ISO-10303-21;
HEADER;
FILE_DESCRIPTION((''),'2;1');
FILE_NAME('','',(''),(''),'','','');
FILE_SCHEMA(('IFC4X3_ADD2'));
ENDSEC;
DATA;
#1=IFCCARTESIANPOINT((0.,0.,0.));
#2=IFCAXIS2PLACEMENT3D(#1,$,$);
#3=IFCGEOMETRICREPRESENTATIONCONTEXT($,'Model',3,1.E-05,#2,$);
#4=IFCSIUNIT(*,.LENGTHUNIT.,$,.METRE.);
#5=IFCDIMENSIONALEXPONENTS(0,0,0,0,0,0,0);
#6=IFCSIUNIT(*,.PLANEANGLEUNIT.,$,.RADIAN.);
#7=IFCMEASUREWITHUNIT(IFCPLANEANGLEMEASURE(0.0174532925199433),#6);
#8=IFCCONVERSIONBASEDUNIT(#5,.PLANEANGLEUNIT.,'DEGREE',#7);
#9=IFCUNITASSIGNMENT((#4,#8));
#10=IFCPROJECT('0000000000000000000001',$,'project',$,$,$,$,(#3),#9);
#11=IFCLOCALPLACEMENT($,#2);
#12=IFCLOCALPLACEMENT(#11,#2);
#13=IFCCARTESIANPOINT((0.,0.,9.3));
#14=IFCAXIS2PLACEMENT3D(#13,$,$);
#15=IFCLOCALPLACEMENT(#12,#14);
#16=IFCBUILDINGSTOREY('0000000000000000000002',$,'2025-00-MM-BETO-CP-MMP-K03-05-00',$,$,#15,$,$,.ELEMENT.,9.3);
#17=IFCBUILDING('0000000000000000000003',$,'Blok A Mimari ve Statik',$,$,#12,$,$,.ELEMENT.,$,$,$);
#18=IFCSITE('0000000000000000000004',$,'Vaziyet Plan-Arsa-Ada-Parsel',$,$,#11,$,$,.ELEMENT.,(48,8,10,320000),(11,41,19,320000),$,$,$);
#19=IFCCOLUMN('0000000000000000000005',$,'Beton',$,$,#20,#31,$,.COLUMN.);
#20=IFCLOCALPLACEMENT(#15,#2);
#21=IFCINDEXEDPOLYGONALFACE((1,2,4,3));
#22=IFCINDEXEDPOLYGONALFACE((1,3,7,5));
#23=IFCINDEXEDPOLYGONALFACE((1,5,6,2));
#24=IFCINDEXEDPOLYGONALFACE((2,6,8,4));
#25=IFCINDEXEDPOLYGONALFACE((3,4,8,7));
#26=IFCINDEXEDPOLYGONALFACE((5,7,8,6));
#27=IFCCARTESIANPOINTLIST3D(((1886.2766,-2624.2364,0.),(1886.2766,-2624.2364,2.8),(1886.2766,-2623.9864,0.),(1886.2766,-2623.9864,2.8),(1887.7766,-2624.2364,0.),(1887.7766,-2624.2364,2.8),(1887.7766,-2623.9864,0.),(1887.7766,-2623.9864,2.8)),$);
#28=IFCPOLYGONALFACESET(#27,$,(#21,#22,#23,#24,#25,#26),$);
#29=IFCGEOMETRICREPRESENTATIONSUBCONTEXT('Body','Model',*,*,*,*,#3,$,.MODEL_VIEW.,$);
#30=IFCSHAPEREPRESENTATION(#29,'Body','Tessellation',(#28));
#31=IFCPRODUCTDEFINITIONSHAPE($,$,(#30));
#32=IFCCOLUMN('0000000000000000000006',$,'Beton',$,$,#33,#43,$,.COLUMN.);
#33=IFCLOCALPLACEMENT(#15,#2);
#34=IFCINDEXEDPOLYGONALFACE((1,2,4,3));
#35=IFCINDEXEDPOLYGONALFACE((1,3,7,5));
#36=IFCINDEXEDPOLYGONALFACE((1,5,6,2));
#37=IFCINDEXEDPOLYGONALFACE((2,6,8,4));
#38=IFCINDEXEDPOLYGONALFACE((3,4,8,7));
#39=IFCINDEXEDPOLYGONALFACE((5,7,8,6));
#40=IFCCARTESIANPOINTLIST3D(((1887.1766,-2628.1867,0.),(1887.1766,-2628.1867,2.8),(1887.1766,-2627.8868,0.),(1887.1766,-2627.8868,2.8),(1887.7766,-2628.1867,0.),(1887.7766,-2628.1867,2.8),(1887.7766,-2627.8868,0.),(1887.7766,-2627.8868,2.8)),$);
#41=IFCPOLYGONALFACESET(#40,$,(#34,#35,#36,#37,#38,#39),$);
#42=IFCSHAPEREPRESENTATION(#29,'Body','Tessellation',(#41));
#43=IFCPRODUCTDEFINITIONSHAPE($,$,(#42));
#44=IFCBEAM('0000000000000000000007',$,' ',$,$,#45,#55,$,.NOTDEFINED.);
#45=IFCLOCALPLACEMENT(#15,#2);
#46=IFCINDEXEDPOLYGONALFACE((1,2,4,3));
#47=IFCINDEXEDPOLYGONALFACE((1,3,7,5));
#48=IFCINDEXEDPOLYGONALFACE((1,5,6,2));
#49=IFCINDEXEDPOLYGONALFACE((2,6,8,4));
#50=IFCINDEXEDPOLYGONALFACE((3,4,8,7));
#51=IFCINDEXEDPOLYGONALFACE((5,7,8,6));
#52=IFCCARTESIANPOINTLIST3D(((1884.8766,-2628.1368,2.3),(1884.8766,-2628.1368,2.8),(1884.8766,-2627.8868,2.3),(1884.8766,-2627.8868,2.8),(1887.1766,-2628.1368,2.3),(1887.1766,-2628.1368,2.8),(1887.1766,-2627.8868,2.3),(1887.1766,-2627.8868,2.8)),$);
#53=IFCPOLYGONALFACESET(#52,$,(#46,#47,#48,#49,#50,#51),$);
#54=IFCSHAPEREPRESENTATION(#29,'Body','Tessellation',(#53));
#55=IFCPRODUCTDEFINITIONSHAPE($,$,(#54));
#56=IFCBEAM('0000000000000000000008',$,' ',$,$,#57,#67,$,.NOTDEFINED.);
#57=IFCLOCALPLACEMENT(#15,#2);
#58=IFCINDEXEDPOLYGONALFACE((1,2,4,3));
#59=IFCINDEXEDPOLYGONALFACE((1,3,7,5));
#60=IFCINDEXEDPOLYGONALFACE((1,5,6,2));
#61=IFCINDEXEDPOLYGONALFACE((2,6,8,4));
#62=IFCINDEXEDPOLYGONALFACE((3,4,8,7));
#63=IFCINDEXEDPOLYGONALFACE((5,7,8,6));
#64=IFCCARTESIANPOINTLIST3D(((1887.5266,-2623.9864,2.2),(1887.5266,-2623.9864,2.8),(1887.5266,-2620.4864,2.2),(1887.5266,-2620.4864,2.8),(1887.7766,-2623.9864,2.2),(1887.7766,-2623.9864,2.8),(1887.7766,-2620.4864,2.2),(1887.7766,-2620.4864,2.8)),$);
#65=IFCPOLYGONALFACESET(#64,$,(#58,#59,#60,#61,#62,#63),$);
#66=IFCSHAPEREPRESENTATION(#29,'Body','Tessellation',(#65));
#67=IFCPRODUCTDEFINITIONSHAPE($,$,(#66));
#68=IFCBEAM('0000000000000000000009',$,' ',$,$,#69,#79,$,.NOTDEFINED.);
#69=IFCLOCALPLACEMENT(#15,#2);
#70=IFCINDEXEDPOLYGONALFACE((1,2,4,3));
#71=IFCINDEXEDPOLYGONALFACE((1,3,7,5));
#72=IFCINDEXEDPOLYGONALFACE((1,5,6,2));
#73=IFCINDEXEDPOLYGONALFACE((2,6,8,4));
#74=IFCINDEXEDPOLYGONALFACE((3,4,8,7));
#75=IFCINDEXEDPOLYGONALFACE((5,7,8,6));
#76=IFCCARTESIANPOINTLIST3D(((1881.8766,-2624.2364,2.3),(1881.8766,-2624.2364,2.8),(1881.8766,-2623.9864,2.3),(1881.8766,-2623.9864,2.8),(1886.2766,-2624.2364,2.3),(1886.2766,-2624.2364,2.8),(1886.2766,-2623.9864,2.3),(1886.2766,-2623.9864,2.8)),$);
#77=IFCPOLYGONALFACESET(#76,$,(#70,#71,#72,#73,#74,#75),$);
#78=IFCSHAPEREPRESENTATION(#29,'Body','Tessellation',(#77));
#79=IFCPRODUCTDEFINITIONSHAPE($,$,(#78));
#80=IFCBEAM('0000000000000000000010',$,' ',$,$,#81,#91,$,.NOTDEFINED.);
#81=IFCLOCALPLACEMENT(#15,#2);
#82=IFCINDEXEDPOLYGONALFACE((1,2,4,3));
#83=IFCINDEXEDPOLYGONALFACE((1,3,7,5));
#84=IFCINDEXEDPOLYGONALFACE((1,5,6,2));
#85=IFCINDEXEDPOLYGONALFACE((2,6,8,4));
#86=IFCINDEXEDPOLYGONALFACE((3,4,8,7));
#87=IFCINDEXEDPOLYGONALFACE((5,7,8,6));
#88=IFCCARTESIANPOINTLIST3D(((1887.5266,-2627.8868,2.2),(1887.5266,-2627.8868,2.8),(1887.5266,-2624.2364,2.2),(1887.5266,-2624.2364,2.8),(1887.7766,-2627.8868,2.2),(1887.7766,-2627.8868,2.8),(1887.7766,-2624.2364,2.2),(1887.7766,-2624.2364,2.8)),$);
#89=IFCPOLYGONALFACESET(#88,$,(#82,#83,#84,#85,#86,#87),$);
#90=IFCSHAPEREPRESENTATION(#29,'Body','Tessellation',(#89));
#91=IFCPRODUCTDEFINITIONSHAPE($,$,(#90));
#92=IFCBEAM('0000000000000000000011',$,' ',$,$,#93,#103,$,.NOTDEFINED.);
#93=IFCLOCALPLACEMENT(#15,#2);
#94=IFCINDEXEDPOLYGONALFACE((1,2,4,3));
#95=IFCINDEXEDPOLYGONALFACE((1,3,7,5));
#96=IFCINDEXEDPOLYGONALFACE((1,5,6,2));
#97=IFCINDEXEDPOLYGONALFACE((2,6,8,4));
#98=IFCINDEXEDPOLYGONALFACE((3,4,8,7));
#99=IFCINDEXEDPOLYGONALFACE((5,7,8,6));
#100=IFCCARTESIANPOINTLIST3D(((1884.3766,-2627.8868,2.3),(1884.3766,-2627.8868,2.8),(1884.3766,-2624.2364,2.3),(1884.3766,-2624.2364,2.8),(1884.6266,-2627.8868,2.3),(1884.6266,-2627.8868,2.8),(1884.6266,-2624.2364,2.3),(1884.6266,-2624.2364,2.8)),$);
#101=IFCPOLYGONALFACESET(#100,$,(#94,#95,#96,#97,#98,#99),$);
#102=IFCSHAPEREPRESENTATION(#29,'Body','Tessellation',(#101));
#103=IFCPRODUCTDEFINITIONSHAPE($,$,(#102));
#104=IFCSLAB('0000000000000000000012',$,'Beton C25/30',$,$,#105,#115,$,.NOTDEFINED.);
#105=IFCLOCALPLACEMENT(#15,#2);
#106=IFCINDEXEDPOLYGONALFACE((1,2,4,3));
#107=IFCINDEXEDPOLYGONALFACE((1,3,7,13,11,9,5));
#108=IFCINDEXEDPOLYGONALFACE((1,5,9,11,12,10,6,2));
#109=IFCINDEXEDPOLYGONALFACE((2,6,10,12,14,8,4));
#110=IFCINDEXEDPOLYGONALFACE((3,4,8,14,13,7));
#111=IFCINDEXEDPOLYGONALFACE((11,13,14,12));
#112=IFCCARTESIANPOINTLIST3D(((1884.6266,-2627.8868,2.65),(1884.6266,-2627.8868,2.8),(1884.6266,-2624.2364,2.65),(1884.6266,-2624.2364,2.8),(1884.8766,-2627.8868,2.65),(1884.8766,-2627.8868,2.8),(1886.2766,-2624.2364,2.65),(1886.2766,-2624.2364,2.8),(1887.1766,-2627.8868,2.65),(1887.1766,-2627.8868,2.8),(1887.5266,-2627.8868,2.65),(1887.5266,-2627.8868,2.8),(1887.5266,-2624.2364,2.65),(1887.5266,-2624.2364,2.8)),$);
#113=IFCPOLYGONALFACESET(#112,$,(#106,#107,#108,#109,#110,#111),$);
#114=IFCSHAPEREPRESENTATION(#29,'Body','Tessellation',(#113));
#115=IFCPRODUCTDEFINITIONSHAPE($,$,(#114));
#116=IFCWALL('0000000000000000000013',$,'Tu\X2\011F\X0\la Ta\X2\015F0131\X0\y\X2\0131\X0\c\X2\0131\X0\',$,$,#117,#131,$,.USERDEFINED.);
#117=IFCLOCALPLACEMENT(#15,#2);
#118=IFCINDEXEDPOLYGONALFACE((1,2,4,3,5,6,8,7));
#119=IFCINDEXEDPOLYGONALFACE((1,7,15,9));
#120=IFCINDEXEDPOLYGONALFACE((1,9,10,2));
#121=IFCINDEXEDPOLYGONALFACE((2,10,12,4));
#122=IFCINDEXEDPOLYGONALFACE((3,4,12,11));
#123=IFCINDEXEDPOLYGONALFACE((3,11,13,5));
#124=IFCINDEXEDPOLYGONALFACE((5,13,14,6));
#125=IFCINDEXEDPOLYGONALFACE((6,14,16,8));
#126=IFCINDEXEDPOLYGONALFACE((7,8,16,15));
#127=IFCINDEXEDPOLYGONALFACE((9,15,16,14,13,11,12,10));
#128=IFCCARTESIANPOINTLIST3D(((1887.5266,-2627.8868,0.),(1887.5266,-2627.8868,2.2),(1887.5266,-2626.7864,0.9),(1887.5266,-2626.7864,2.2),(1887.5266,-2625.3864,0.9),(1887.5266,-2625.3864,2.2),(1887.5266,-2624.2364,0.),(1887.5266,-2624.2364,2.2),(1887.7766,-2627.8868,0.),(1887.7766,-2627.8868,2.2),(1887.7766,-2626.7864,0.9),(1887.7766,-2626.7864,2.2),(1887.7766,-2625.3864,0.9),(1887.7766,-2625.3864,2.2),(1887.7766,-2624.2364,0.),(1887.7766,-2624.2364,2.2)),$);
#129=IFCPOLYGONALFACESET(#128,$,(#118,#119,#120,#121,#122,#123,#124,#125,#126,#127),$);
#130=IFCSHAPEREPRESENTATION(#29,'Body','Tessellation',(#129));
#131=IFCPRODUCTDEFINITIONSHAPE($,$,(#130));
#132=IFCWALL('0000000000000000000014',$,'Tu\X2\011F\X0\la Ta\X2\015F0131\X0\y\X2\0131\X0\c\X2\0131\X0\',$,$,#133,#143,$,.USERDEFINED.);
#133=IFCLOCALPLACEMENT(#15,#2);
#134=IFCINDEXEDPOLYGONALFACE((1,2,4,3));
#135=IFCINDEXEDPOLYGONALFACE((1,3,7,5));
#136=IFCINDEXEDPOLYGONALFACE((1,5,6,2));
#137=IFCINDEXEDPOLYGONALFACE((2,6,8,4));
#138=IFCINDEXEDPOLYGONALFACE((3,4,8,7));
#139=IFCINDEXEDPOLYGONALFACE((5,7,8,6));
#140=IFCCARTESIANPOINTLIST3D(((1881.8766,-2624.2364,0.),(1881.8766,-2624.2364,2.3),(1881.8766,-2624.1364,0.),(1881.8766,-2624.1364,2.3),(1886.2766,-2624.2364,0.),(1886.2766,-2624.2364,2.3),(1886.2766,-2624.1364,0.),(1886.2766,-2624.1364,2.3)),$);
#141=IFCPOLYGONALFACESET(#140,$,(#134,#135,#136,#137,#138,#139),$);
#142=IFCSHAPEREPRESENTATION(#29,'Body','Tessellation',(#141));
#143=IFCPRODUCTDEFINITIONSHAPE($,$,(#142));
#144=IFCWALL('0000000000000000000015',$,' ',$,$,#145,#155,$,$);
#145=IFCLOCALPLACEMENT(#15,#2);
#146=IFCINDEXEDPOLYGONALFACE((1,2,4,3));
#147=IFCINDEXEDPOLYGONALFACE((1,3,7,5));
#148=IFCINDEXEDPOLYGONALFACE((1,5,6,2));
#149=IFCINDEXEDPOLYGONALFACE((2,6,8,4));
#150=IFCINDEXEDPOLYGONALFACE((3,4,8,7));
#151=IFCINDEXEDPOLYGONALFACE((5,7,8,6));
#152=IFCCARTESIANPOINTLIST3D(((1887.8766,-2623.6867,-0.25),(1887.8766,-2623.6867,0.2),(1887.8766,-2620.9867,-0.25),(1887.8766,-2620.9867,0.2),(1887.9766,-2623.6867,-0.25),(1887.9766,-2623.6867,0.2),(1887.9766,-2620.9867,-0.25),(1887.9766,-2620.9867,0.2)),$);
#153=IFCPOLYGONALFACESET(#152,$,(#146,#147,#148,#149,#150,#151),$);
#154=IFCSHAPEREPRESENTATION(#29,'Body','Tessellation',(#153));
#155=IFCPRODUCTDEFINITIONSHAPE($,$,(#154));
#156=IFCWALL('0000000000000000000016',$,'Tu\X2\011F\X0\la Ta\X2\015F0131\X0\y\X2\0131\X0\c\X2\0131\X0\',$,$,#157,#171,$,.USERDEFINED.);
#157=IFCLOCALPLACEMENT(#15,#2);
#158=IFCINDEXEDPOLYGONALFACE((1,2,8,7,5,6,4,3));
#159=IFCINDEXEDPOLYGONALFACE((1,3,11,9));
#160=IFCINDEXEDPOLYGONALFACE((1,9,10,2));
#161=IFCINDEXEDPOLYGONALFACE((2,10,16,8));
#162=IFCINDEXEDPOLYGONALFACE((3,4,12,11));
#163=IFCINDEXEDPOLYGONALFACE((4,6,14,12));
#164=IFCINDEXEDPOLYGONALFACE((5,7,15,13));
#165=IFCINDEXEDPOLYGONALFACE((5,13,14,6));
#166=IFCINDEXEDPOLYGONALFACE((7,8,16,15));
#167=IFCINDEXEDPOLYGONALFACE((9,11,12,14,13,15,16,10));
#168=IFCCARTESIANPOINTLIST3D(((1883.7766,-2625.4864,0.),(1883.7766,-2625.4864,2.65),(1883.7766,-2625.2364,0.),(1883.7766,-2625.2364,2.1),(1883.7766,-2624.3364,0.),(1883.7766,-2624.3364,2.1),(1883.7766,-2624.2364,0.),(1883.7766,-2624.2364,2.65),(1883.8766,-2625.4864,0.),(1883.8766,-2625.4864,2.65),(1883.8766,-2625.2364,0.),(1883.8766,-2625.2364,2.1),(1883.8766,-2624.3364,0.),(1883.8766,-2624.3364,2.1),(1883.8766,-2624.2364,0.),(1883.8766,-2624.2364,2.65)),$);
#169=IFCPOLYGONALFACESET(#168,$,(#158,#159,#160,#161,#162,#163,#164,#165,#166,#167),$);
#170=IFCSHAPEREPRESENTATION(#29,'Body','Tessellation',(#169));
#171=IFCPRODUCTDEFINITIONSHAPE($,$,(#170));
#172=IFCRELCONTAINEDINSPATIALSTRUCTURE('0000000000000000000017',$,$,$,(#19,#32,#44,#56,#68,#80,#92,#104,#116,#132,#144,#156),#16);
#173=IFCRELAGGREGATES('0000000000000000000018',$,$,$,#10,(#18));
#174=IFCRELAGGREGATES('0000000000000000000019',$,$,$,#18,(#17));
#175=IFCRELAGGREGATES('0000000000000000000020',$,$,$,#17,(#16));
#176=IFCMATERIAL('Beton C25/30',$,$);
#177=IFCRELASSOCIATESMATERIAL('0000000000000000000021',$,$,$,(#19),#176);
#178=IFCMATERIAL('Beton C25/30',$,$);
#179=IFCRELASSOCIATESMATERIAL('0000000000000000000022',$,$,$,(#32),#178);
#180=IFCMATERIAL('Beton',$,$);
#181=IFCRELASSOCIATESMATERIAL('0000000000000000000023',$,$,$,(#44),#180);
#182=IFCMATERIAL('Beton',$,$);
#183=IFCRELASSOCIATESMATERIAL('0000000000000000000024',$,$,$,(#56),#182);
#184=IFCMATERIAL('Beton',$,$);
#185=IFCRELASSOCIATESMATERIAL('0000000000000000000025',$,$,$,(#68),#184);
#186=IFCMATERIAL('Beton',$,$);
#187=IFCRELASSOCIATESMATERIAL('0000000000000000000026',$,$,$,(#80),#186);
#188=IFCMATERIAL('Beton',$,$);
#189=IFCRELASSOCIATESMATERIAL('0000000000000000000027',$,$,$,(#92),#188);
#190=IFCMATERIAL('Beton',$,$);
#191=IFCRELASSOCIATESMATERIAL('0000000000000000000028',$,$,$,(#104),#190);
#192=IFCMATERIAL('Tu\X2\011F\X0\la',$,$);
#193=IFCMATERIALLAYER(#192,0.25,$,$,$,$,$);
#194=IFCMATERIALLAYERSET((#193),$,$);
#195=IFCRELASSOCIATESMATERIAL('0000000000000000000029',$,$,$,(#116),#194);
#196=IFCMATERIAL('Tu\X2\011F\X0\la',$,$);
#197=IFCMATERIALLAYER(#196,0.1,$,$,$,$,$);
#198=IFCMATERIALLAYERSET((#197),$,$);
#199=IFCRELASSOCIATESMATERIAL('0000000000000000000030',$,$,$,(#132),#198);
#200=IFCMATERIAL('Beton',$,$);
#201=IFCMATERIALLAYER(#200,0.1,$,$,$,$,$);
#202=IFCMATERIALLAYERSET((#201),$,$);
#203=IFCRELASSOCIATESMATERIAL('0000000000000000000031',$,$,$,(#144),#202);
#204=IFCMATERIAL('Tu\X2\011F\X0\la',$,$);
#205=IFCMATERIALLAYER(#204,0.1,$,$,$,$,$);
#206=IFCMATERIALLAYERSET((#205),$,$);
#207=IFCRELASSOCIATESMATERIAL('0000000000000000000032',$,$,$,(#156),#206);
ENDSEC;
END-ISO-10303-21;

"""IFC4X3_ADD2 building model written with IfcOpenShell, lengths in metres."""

from ifc_helpers import new_model, entity, si_unit, converted_unit, frame, frame_2d, origin, origin_with_axes, place, context, subcontext, project, spatial, polyline, rectangle, outline, extrude, material, layer, layer_set, layer_usage, element, save


model = new_model("IFC4X3_ADD2")

# Units and contexts
model_context = context("Model", 3, precision=1e-05, world=origin())
body_context = subcontext(model_context, "Body", "Model", "MODEL_VIEW")
ifc_project = project(units=[si_unit("LENGTHUNIT", "METRE"), converted_unit("PLANEANGLEUNIT", "DEGREE", entity("IfcPlaneAngleMeasure", 0.0174532925199433), si_unit("PLANEANGLEUNIT", "RADIAN"), dimensions=[0, 0, 0, 0, 0, 0, 0])], contexts=[model_context])

# Site, building, storey
site_placement = place(None, origin())
site = spatial("IfcSite", under=ifc_project, at=site_placement, Name="Vaziyet Plan-Arsa-Ada-Parsel", CompositionType="ELEMENT", RefLatitude=(48, 8, 10, 320000), RefLongitude=(11, 41, 19, 320000))
building_placement = place(site_placement, origin())
building = spatial("IfcBuilding", under=site, at=building_placement, Name="Blok A Mimari ve Statik", CompositionType="ELEMENT")
storey_placement = place(building_placement, frame((0.0, 0.0, 9.3)))
storey = spatial("IfcBuildingStorey", under=building, at=storey_placement, Name="2025-00-MM-BETO-CP-MMP-K03-05-00", CompositionType="ELEMENT", Elevation=9.3)

# Columns
ifc_material_1 = material(Name="Beton C25/30")
column_1_placement = place(storey_placement, frame((1886.2766, -2624.2364, 0.0)))
element("IfcColumn", 1, at=column_1_placement, inside=storey, material=ifc_material_1, Name="Beton", PredefinedType="COLUMN", context=body_context, shape_type="SweptSolid", body=[
    extrude(outline(polyline([(1.5, 0.0), (1.5, 0.25), (0.0, 0.25), (0.0, 0.0), (1.5, 0.0)])), origin_with_axes(), (0.0, 0.0, 1.0), 2.8),
])
ifc_material_2 = material(Name="Beton C25/30")
column_2_placement = place(storey_placement, frame((1887.1766, -2628.1867, 0.0)))
element("IfcColumn", 2, at=column_2_placement, inside=storey, material=ifc_material_2, Name="Beton", PredefinedType="COLUMN", context=body_context, shape_type="SweptSolid", body=[
    extrude(outline(polyline([(0.0, 0.3), (0.0, 0.0), (0.6, 0.0), (0.6, 0.3), (0.0, 0.3)])), origin_with_axes(), (0.0, 0.0, 1.0), 2.8),
])

# Beams
ifc_material_3 = material(Name="Beton")
beam_1_placement = place(storey_placement, frame((1887.1766, -2627.8868, 2.3), z_axis=(0.0, 0.0, 1.0), x_axis=(-1.0, 0.0, 0.0)))
element("IfcBeam", 3, at=beam_1_placement, inside=storey, material=ifc_material_3, Name=" ", PredefinedType="NOTDEFINED", context=body_context, shape_type="SweptSolid", body=[
    extrude(rectangle(XDim=0.25, YDim=0.5, at=frame_2d((0.125, 0.25), x_axis=(1.0, 0.0))), frame((0.0, 0.0, 0.0), z_axis=(1.0, 0.0, 0.0), x_axis=(0.0, 1.0, 0.0)), (0.0, 0.0, 1.0), 2.3),
])
ifc_material_4 = material(Name="Beton")
beam_2_placement = place(storey_placement, frame((1887.7766, -2623.9864, 2.2), z_axis=(0.0, 0.0, 1.0), x_axis=(0.0, 1.0, 0.0)))
element("IfcBeam", 4, at=beam_2_placement, inside=storey, material=ifc_material_4, Name=" ", PredefinedType="NOTDEFINED", context=body_context, shape_type="SweptSolid", body=[
    extrude(rectangle(XDim=0.25, YDim=0.6, at=frame_2d((0.125, 0.3), x_axis=(1.0, 0.0))), frame((0.0, 0.0, 0.0), z_axis=(1.0, 0.0, 0.0), x_axis=(0.0, 1.0, 0.0)), (0.0, 0.0, 1.0), 3.5),
])
ifc_material_5 = material(Name="Beton")
beam_3_placement = place(storey_placement, frame((1881.8766, -2624.2364, 2.3)))
element("IfcBeam", 5, at=beam_3_placement, inside=storey, material=ifc_material_5, Name=" ", PredefinedType="NOTDEFINED", context=body_context, shape_type="SweptSolid", body=[
    extrude(rectangle(XDim=0.25, YDim=0.5, at=frame_2d((0.125, 0.25), x_axis=(1.0, 0.0))), frame((0.0, 0.0, 0.0), z_axis=(1.0, 0.0, 0.0), x_axis=(0.0, 1.0, 0.0)), (0.0, 0.0, 1.0), 4.4),
])
ifc_material_6 = material(Name="Beton")
beam_4_placement = place(storey_placement, frame((1887.7766, -2627.8868, 2.2), z_axis=(0.0, 0.0, 1.0), x_axis=(0.0, 1.0, 0.0)))
element("IfcBeam", 6, at=beam_4_placement, inside=storey, material=ifc_material_6, Name=" ", PredefinedType="NOTDEFINED", context=body_context, shape_type="SweptSolid", body=[
    extrude(rectangle(XDim=0.25, YDim=0.6, at=frame_2d((0.125, 0.3), x_axis=(1.0, 0.0))), frame((0.0, 0.0, 0.0), z_axis=(1.0, 0.0, 0.0), x_axis=(0.0, 1.0, 0.0)), (0.0, 0.0, 1.0), 3.6503),
])
ifc_material_7 = material(Name="Beton")
beam_5_placement = place(storey_placement, frame((1884.3766, -2624.2364, 2.3), z_axis=(0.0, 0.0, 1.0), x_axis=(0.0, -1.0, 0.0)))
element("IfcBeam", 7, at=beam_5_placement, inside=storey, material=ifc_material_7, Name=" ", PredefinedType="NOTDEFINED", context=body_context, shape_type="SweptSolid", body=[
    extrude(rectangle(XDim=0.25, YDim=0.5, at=frame_2d((0.125, 0.25), x_axis=(1.0, 0.0))), frame((0.0, 0.0, 0.0), z_axis=(1.0, 0.0, 0.0), x_axis=(0.0, 1.0, 0.0)), (0.0, 0.0, 1.0), 3.6503),
])

# Slab
ifc_material_8 = material(Name="Beton")
slab_placement = place(storey_placement, frame((1884.6266, -2627.8868, 2.65)))
element("IfcSlab", 8, at=slab_placement, inside=storey, material=ifc_material_8, Name="Beton C25/30", PredefinedType="NOTDEFINED", context=body_context, shape_type="SweptSolid", body=[
    extrude(outline(polyline([(0.0, 3.6503), (0.0, 0.0), (0.25, 0.0), (2.55, 0.0), (2.9, 0.0), (2.9, 3.6503), (1.65, 3.6503), (0.0, 3.6503)])), origin_with_axes(), (0.0, 0.0, 1.0), 0.15),
])

# Wall, opening
ifc_material_9 = material(Name="Tuğla")
ifc_layer_1 = layer(ifc_material_9, 0.25)
ifc_layer_set_1 = layer_set([ifc_layer_1])
ifc_layer_usage_1 = layer_usage(ifc_layer_set_1, "AXIS2", "POSITIVE", 0.0)
wall_1_placement = place(storey_placement, frame((1887.7766, -2627.8868, 0.0), z_axis=(0.0, 0.0, 1.0), x_axis=(0.0, 1.0, 0.0)))
wall_1 = element("IfcWall", 9, at=wall_1_placement, inside=storey, material=ifc_layer_usage_1, Name="Tuğla Taşıyıcı", PredefinedType="USERDEFINED", context=body_context, shape_type="SweptSolid", body=[
    extrude(rectangle(XDim=3.6503, YDim=0.25, at=frame_2d((1.8252, 0.125), x_axis=(1.0, 0.0))), origin_with_axes(), (0.0, 0.0, 1.0), 2.2),
])
opening_1_placement = place(wall_1_placement, frame((1.1003, 0.0, 0.9), z_axis=(0.0, 1.0, 0.0), x_axis=(0.0, 0.0, 1.0)))
element("IfcOpeningElement", 10, at=opening_1_placement, cuts=wall_1, PredefinedType="OPENING", context=body_context, shape_type="SweptSolid", body=[
    extrude(outline(polyline([(1.35, 1.4), (1.35, 0.0), (0.0, 0.0), (0.0, 1.4), (1.35, 1.4)])), origin_with_axes(), (0.0, 0.0, 1.0), 0.25),
])

# Walls
ifc_material_10 = material(Name="Tuğla")
ifc_layer_2 = layer(ifc_material_10, 0.1)
ifc_layer_set_2 = layer_set([ifc_layer_2])
ifc_layer_usage_2 = layer_usage(ifc_layer_set_2, "AXIS2", "POSITIVE", 0.0)
wall_2_placement = place(storey_placement, frame((1881.8766, -2624.2364, 0.0)))
element("IfcWall", 11, at=wall_2_placement, inside=storey, material=ifc_layer_usage_2, Name="Tuğla Taşıyıcı", PredefinedType="USERDEFINED", context=body_context, shape_type="SweptSolid", body=[
    extrude(rectangle(XDim=4.4, YDim=0.1, at=frame_2d((2.2, 0.05), x_axis=(1.0, 0.0))), origin_with_axes(), (0.0, 0.0, 1.0), 2.3),
])
ifc_material_11 = material(Name="Beton")
ifc_layer_3 = layer(ifc_material_11, 0.1)
ifc_layer_set_3 = layer_set([ifc_layer_3])
ifc_layer_usage_3 = layer_usage(ifc_layer_set_3, "AXIS2", "POSITIVE", 0.0)
wall_3_placement = place(storey_placement, frame((1887.9766, -2623.6867, -0.25), z_axis=(0.0, 0.0, 1.0), x_axis=(0.0, 1.0, 0.0)))
element("IfcWall", 12, at=wall_3_placement, inside=storey, material=ifc_layer_usage_3, Name=" ", context=body_context, shape_type="SweptSolid", body=[
    extrude(rectangle(XDim=2.7, YDim=0.1, at=frame_2d((1.35, 0.05), x_axis=(1.0, 0.0))), origin_with_axes(), (0.0, 0.0, 1.0), 0.45),
])

# Wall, opening
ifc_material_12 = material(Name="Tuğla")
ifc_layer_4 = layer(ifc_material_12, 0.1)
ifc_layer_set_4 = layer_set([ifc_layer_4])
ifc_layer_usage_4 = layer_usage(ifc_layer_set_4, "AXIS2", "POSITIVE", 0.0)
wall_4_placement = place(storey_placement, frame((1883.7766, -2624.2364, 0.0), z_axis=(0.0, 0.0, 1.0), x_axis=(0.0, -1.0, 0.0)))
wall_4 = element("IfcWall", 13, at=wall_4_placement, inside=storey, material=ifc_layer_usage_4, Name="Tuğla Taşıyıcı", PredefinedType="USERDEFINED", context=body_context, shape_type="SweptSolid", body=[
    extrude(rectangle(XDim=1.25, YDim=0.1, at=frame_2d((0.625, 0.05), x_axis=(1.0, 0.0))), origin_with_axes(), (0.0, 0.0, 1.0), 2.65),
])
opening_2_placement = place(wall_4_placement, frame((1.0, 0.1, 0.0), z_axis=(0.0, -1.0, 0.0), x_axis=(0.0, 0.0, 1.0)))
element("IfcOpeningElement", 14, at=opening_2_placement, cuts=wall_4, PredefinedType="OPENING", context=body_context, shape_type="SweptSolid", body=[
    extrude(outline(polyline([(2.1, 0.9), (2.1, 0.0), (0.0, 0.0), (0.0, 0.9), (2.1, 0.9)])), origin_with_axes(), (0.0, 0.0, 1.0), 0.1),
])

save(model, "model.ifc")
